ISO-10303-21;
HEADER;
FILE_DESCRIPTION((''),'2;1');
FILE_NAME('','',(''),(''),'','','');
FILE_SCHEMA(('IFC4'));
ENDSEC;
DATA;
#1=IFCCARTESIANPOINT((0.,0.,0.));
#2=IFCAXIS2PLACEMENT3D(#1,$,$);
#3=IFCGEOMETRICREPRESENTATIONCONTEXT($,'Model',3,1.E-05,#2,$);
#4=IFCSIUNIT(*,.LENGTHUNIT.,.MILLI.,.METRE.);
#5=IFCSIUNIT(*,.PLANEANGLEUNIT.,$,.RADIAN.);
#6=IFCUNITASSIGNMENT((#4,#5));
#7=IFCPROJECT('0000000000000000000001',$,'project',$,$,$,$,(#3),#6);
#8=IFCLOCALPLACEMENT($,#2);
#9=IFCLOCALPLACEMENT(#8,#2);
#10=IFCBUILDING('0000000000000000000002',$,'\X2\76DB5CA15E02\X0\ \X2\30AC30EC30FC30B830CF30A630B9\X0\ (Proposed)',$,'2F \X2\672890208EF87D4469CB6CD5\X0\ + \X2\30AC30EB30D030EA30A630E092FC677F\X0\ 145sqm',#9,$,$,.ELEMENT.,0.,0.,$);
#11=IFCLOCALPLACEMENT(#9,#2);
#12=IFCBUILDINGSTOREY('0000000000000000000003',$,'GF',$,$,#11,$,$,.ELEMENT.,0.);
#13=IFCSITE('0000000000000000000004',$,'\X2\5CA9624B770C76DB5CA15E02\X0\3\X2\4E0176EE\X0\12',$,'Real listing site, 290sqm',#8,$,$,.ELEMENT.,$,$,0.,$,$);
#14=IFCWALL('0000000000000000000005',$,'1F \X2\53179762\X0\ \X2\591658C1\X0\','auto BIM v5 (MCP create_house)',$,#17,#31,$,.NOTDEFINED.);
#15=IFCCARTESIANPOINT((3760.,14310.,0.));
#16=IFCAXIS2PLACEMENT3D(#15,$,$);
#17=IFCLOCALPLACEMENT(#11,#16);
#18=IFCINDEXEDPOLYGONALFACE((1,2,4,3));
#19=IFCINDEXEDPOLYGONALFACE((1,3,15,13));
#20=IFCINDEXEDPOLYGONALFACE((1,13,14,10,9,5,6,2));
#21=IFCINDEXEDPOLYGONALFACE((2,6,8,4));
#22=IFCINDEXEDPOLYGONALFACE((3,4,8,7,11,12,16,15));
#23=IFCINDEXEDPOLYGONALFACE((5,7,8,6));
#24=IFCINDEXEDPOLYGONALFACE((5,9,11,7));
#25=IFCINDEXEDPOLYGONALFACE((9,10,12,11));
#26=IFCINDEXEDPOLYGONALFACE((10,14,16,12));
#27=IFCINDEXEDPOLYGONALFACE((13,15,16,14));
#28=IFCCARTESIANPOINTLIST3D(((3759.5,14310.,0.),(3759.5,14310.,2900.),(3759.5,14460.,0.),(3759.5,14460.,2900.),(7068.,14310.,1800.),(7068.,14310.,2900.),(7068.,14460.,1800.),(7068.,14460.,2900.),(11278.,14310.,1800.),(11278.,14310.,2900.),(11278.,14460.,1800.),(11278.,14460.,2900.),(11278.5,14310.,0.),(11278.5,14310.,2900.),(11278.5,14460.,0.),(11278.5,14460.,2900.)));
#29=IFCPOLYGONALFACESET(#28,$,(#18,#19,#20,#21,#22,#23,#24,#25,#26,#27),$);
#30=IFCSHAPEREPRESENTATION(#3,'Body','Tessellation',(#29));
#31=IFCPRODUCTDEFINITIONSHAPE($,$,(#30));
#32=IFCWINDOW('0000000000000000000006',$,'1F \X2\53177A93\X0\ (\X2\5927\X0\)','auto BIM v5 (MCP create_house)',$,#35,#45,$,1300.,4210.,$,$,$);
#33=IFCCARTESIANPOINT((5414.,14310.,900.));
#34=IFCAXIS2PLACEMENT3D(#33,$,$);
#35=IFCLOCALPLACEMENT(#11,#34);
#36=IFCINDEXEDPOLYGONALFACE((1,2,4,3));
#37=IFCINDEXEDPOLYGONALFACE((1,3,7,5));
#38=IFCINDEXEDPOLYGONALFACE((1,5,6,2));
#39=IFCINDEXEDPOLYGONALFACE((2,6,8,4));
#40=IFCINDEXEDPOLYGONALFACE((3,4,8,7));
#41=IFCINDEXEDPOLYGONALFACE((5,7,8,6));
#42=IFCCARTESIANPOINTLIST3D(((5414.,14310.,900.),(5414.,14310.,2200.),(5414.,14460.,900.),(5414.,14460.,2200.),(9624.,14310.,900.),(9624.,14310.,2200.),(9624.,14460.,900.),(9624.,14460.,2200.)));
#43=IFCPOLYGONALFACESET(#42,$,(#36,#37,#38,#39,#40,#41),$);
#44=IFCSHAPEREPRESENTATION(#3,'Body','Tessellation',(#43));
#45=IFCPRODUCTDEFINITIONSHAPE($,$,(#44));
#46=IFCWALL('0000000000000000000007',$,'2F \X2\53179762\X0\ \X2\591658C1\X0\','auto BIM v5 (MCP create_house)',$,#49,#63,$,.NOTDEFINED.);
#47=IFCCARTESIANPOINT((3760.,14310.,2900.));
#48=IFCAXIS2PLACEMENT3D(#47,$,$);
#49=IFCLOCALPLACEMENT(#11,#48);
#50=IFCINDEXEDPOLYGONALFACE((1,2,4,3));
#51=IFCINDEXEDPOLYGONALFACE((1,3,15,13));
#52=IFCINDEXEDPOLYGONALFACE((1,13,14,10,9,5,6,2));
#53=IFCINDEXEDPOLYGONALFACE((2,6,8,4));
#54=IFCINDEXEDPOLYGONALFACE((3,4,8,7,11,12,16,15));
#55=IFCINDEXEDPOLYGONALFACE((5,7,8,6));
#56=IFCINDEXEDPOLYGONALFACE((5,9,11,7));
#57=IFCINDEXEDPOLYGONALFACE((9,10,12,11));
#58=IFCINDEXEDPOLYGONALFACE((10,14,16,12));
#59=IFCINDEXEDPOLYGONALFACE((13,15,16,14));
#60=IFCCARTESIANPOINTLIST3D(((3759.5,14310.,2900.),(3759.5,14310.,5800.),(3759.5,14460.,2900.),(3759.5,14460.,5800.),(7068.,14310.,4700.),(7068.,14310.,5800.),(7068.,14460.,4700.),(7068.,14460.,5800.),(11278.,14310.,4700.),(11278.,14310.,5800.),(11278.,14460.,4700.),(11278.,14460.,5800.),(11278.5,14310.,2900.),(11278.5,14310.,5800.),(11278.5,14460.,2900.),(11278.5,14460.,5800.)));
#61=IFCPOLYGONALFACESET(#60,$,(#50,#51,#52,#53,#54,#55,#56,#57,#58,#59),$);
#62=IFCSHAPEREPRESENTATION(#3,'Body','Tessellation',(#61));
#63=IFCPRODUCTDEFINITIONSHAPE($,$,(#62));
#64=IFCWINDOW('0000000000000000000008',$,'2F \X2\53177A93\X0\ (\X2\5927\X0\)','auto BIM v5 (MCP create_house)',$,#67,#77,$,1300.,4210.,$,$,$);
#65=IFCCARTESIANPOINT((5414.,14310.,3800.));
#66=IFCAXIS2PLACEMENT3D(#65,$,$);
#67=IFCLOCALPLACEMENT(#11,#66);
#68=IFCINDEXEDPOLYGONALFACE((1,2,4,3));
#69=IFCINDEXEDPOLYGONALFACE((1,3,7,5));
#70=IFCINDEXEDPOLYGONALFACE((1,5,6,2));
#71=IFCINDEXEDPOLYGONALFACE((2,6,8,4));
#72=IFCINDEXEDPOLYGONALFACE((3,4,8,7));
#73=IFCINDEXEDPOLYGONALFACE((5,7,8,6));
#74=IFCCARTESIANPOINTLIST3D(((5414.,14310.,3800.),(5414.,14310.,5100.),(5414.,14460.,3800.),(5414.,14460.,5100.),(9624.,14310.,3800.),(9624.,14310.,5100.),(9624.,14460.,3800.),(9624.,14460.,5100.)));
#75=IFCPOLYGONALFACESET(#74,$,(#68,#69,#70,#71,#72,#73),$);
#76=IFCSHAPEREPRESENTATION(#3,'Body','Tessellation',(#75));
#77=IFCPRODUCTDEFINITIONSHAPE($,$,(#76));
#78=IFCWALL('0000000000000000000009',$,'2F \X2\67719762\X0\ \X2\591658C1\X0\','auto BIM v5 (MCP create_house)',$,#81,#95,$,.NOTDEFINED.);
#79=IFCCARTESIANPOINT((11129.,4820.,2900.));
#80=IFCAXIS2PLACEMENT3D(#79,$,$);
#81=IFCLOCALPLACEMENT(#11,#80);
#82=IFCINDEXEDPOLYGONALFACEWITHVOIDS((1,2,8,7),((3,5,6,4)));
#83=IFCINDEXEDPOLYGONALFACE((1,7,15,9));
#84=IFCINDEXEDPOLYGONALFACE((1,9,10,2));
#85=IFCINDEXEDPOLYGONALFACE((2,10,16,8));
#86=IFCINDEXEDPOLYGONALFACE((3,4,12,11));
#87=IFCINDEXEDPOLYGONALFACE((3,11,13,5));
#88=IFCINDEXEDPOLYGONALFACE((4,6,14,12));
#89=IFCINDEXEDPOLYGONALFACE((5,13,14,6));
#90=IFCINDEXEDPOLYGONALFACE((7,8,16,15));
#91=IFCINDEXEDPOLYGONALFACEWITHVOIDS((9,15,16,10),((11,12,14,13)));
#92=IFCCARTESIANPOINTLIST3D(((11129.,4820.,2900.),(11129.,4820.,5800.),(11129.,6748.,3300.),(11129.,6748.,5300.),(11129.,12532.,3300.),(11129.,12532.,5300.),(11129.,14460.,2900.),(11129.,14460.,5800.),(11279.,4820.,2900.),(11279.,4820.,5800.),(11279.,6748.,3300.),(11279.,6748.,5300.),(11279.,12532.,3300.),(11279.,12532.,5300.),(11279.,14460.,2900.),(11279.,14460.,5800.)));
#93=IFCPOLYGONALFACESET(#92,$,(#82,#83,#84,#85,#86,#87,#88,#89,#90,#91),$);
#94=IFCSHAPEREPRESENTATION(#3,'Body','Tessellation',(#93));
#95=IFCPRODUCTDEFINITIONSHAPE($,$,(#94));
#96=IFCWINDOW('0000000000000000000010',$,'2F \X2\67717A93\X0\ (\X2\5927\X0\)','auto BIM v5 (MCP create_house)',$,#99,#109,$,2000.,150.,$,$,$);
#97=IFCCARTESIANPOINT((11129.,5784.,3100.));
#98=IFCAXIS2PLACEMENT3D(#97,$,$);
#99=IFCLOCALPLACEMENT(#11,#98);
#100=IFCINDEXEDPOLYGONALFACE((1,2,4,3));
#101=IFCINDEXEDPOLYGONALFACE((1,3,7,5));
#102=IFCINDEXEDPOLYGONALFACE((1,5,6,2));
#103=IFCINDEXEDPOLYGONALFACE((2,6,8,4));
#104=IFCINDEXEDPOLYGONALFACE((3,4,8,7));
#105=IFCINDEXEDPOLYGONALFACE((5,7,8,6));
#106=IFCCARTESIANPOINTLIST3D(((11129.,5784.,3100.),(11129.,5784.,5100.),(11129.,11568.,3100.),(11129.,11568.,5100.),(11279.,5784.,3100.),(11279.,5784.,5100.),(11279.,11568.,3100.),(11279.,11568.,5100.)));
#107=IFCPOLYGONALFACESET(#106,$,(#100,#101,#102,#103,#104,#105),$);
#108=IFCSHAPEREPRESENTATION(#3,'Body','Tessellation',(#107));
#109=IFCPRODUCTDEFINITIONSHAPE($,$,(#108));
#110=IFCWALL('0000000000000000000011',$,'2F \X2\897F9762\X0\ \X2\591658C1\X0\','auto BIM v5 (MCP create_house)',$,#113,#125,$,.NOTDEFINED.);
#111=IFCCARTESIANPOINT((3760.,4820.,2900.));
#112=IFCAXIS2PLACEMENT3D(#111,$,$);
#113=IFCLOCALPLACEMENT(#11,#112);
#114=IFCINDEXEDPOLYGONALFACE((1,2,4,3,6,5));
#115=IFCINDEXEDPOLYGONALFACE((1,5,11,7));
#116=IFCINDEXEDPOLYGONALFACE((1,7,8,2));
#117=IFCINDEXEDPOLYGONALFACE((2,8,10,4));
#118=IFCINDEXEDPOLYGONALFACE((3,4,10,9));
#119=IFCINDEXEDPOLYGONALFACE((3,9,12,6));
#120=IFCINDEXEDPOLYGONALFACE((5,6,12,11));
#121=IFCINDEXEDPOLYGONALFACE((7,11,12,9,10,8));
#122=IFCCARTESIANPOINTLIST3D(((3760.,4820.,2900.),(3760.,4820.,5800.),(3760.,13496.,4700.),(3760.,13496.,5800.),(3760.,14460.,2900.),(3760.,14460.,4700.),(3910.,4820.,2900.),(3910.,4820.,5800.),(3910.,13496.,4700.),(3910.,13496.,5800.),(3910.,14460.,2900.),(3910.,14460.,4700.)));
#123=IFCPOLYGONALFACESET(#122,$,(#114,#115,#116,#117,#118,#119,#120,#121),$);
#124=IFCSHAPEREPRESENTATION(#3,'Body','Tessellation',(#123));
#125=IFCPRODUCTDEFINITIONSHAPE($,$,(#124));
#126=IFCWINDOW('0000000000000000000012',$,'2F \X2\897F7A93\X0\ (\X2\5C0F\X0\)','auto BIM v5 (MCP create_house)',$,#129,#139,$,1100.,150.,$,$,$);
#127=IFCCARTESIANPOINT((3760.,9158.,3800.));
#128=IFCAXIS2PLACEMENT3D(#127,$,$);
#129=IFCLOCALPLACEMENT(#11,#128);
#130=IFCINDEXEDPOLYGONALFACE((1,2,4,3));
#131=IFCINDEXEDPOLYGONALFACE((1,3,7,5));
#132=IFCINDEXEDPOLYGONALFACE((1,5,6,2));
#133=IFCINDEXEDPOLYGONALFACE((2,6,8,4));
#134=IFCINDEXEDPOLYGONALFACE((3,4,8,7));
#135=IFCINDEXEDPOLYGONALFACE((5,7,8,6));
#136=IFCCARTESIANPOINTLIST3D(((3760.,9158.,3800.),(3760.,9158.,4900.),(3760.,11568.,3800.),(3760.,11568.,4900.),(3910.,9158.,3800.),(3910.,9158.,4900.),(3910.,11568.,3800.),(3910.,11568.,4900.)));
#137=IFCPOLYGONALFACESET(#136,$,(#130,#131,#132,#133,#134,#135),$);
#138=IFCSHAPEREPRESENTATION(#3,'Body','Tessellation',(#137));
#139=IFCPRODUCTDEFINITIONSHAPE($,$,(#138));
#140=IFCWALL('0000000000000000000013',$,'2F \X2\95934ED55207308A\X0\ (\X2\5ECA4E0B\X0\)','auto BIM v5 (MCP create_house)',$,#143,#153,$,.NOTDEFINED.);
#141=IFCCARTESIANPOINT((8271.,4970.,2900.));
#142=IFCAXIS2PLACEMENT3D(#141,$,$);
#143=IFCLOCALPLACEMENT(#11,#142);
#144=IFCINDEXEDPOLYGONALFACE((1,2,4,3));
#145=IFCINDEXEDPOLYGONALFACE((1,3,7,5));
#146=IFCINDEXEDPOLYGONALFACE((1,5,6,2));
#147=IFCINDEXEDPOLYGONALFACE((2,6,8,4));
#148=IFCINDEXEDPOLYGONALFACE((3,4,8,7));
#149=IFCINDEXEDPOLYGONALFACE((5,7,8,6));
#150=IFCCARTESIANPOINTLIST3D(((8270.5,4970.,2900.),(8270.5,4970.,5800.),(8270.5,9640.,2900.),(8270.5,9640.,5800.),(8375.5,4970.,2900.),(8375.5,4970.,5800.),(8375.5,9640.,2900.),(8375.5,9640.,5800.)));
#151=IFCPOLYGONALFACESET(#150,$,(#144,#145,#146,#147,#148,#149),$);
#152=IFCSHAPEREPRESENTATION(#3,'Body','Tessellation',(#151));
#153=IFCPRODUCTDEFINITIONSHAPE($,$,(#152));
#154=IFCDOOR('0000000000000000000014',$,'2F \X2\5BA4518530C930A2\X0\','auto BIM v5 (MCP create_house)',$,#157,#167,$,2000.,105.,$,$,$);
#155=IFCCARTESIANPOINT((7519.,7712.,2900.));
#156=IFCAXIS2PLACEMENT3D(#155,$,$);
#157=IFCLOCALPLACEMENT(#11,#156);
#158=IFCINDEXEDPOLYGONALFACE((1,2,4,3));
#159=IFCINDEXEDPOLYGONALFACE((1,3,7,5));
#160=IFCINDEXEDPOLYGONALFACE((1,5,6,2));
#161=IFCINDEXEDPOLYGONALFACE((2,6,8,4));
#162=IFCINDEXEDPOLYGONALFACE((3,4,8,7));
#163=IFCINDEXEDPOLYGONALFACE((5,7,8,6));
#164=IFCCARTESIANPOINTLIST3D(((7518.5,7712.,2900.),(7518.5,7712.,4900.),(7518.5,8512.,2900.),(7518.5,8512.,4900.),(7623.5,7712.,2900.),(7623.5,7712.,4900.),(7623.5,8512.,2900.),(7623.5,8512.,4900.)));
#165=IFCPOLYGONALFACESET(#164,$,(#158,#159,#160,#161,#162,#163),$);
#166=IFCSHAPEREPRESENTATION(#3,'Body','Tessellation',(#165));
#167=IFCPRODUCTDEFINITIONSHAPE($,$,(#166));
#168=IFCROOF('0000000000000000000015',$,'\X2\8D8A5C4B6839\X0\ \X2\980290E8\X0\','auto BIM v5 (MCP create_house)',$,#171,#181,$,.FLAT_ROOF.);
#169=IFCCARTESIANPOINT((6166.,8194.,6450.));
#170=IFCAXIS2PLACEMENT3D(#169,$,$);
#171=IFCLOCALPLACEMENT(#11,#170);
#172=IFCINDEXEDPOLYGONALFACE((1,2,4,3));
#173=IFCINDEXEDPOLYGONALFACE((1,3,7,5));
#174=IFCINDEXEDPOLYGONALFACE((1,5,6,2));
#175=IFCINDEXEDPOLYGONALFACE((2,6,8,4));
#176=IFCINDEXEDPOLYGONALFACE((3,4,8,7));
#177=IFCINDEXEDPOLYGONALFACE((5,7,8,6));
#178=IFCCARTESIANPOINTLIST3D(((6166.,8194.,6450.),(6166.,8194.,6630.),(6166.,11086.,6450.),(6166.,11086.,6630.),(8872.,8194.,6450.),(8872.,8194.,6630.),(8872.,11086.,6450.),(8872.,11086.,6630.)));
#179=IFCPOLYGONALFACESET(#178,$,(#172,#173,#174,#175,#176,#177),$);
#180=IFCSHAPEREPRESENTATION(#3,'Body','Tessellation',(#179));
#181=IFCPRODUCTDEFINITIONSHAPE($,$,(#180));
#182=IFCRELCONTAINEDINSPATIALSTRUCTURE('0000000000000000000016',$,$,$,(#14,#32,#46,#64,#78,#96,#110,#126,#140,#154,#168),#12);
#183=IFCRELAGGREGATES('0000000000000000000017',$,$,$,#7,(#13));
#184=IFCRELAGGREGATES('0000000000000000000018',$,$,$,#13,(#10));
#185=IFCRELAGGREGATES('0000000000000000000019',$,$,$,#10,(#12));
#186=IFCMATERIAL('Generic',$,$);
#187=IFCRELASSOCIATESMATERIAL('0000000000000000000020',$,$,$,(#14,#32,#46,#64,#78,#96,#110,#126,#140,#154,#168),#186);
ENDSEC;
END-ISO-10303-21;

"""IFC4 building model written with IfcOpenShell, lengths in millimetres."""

from ifc_helpers import new_model, si_unit, frame, frame_2d, origin, place, context, project, spatial, rectangle, extrude, material, element, fill, save


model = new_model("IFC4")

# Units and contexts
model_context = context("Model", 3, precision=1e-05, world=origin())
ifc_project = project(units=[si_unit("LENGTHUNIT", "METRE", prefix="MILLI"), si_unit("PLANEANGLEUNIT", "RADIAN")], contexts=[model_context])

# Site, building, storey
site_placement = place(None, origin())
site = spatial("IfcSite", under=ifc_project, at=site_placement, Name="岩手県盛岡市3丁目12", ObjectType="Real listing site, 290sqm", CompositionType="ELEMENT", RefElevation=0.0)
building_placement = place(site_placement, origin())
building = spatial("IfcBuilding", under=site, at=building_placement, Name="盛岡市 ガレージハウス (Proposed)", ObjectType="2F 木造軸組構法 + ガルバリウム鋼板 145sqm", CompositionType="ELEMENT", ElevationOfRefHeight=0.0, ElevationOfTerrain=0.0)
storey_placement = place(building_placement, origin())
storey = spatial("IfcBuildingStorey", under=building, at=storey_placement, Name="GF", CompositionType="ELEMENT", Elevation=0.0)

# Wall, opening, window
ifc_material = material(Name="Generic")
wall_1_placement = place(storey_placement, frame((3760.0, 14310.0, 0.0)))
wall_1 = element("IfcWall", 1, at=wall_1_placement, inside=storey, material=ifc_material, Name="1F 北面 外壁", Description="auto BIM v5 (MCP create_house)", PredefinedType="NOTDEFINED", context=model_context, shape_type="SweptSolid", body=[
    extrude(rectangle(XDim=7519.0, YDim=150.0, at=frame_2d((3759.0, 75.0))), frame((3760.0, 14310.0, 0.0)), (0.0, 0.0, 1.0), 2900.0),
])
opening_1_placement = place(storey_placement, frame((5414.0, 14310.0, 900.0)))
opening_1 = element("IfcOpeningElement", 2, at=opening_1_placement, cuts=wall_1, PredefinedType="NOTDEFINED", context=model_context, shape_type="SweptSolid", body=[
    extrude(rectangle(XDim=4210.0, YDim=150.0, at=frame_2d((2105.0, 75.0))), frame((5414.0, 14310.0, 900.0)), (0.0, 0.0, 1.0), 1300.0),
])
window_1_placement = place(storey_placement, frame((5414.0, 14310.0, 900.0)))
window_1 = element("IfcWindow", 3, at=window_1_placement, inside=storey, material=ifc_material, Name="1F 北窓 (大)", Description="auto BIM v5 (MCP create_house)", OverallHeight=1300.0, OverallWidth=4210.0, context=model_context, shape_type="SweptSolid", body=[
    extrude(rectangle(XDim=4210.0, YDim=150.0, at=frame_2d((2105.0, 75.0))), frame((5414.0, 14310.0, 900.0)), (0.0, 0.0, 1.0), 1300.0),
])
fill(opening_1, window_1)

# Walls, openings, windows
wall_2_placement = place(storey_placement, frame((3760.0, 14310.0, 2900.0)))
wall_2 = element("IfcWall", 4, at=wall_2_placement, inside=storey, material=ifc_material, Name="2F 北面 外壁", Description="auto BIM v5 (MCP create_house)", PredefinedType="NOTDEFINED", context=model_context, shape_type="SweptSolid", body=[
    extrude(rectangle(XDim=7519.0, YDim=150.0, at=frame_2d((3759.0, 75.0))), frame((3760.0, 14310.0, 2900.0)), (0.0, 0.0, 1.0), 2900.0),
])
opening_2_placement = place(storey_placement, frame((5414.0, 14310.0, 3800.0)))
opening_2 = element("IfcOpeningElement", 5, at=opening_2_placement, cuts=wall_2, PredefinedType="NOTDEFINED", context=model_context, shape_type="SweptSolid", body=[
    extrude(rectangle(XDim=4210.0, YDim=150.0, at=frame_2d((2105.0, 75.0))), frame((5414.0, 14310.0, 3800.0)), (0.0, 0.0, 1.0), 1300.0),
])
window_2_placement = place(storey_placement, frame((5414.0, 14310.0, 3800.0)))
window_2 = element("IfcWindow", 6, at=window_2_placement, inside=storey, material=ifc_material, Name="2F 北窓 (大)", Description="auto BIM v5 (MCP create_house)", OverallHeight=1300.0, OverallWidth=4210.0, context=model_context, shape_type="SweptSolid", body=[
    extrude(rectangle(XDim=4210.0, YDim=150.0, at=frame_2d((2105.0, 75.0))), frame((5414.0, 14310.0, 3800.0)), (0.0, 0.0, 1.0), 1300.0),
])
fill(opening_2, window_2)
wall_3_placement = place(storey_placement, frame((11129.0, 4820.0, 2900.0)))
wall_3 = element("IfcWall", 7, at=wall_3_placement, inside=storey, material=ifc_material, Name="2F 東面 外壁", Description="auto BIM v5 (MCP create_house)", PredefinedType="NOTDEFINED", context=model_context, shape_type="SweptSolid", body=[
    extrude(rectangle(XDim=150.0, YDim=9640.0, at=frame_2d((75.0, 4820.0))), frame((11129.0, 4820.0, 2900.0)), (0.0, 0.0, 1.0), 2900.0),
])
opening_3_placement = place(storey_placement, frame((11129.0, 5784.0, 3100.0)))
opening_3 = element("IfcOpeningElement", 8, at=opening_3_placement, cuts=wall_3, PredefinedType="NOTDEFINED", context=model_context, shape_type="SweptSolid", body=[
    extrude(rectangle(XDim=150.0, YDim=5784.0, at=frame_2d((75.0, 2892.0))), frame((11129.0, 5784.0, 3100.0)), (0.0, 0.0, 1.0), 2000.0),
])
window_3_placement = place(storey_placement, frame((11129.0, 5784.0, 3100.0)))
window_3 = element("IfcWindow", 9, at=window_3_placement, inside=storey, material=ifc_material, Name="2F 東窓 (大)", Description="auto BIM v5 (MCP create_house)", OverallHeight=2000.0, OverallWidth=150.0, context=model_context, shape_type="SweptSolid", body=[
    extrude(rectangle(XDim=150.0, YDim=5784.0, at=frame_2d((75.0, 2892.0))), frame((11129.0, 5784.0, 3100.0)), (0.0, 0.0, 1.0), 2000.0),
])
fill(opening_3, window_3)
wall_4_placement = place(storey_placement, frame((3760.0, 4820.0, 2900.0)))
wall_4 = element("IfcWall", 10, at=wall_4_placement, inside=storey, material=ifc_material, Name="2F 西面 外壁", Description="auto BIM v5 (MCP create_house)", PredefinedType="NOTDEFINED", context=model_context, shape_type="SweptSolid", body=[
    extrude(rectangle(XDim=150.0, YDim=9640.0, at=frame_2d((75.0, 4820.0))), frame((3760.0, 4820.0, 2900.0)), (0.0, 0.0, 1.0), 2900.0),
])
opening_4_placement = place(storey_placement, frame((3760.0, 9158.0, 3800.0)))
opening_4 = element("IfcOpeningElement", 11, at=opening_4_placement, cuts=wall_4, PredefinedType="NOTDEFINED", context=model_context, shape_type="SweptSolid", body=[
    extrude(rectangle(XDim=150.0, YDim=2410.0, at=frame_2d((75.0, 1205.0))), frame((3760.0, 9158.0, 3800.0)), (0.0, 0.0, 1.0), 1100.0),
])
window_4_placement = place(storey_placement, frame((3760.0, 9158.0, 3800.0)))
window_4 = element("IfcWindow", 12, at=window_4_placement, inside=storey, material=ifc_material, Name="2F 西窓 (小)", Description="auto BIM v5 (MCP create_house)", OverallHeight=1100.0, OverallWidth=150.0, context=model_context, shape_type="SweptSolid", body=[
    extrude(rectangle(XDim=150.0, YDim=2410.0, at=frame_2d((75.0, 1205.0))), frame((3760.0, 9158.0, 3800.0)), (0.0, 0.0, 1.0), 1100.0),
])
fill(opening_4, window_4)

# Wall
wall_5_placement = place(storey_placement, frame((8271.0, 4970.0, 2900.0)))
element("IfcWall", 13, at=wall_5_placement, inside=storey, material=ifc_material, Name="2F 間仕切り (廊下)", Description="auto BIM v5 (MCP create_house)", PredefinedType="NOTDEFINED", context=model_context, shape_type="SweptSolid", body=[
    extrude(rectangle(XDim=105.0, YDim=4670.0, at=frame_2d((52.0, 2335.0))), frame((8271.0, 4970.0, 2900.0)), (0.0, 0.0, 1.0), 2900.0),
])

# Door
door_placement = place(storey_placement, frame((7519.0, 7712.0, 2900.0)))
element("IfcDoor", 14, at=door_placement, inside=storey, material=ifc_material, Name="2F 室内ドア", Description="auto BIM v5 (MCP create_house)", OverallHeight=2000.0, OverallWidth=105.0, context=model_context, shape_type="SweptSolid", body=[
    extrude(rectangle(XDim=105.0, YDim=800.0, at=frame_2d((52.0, 400.0))), frame((7519.0, 7712.0, 2900.0)), (0.0, 0.0, 1.0), 2000.0),
])

# Roof
roof_placement = place(storey_placement, frame((6166.0, 8194.0, 6450.0)))
element("IfcRoof", 15, at=roof_placement, inside=storey, material=ifc_material, Name="越屋根 頂部", Description="auto BIM v5 (MCP create_house)", PredefinedType="FLAT_ROOF", context=model_context, shape_type="SweptSolid", body=[
    extrude(rectangle(XDim=2706.0, YDim=2892.0, at=frame_2d((1353.0, 1446.0))), frame((6166.0, 8194.0, 6450.0)), (0.0, 0.0, 1.0), 180.0),
])

save(model, "model.ifc")
